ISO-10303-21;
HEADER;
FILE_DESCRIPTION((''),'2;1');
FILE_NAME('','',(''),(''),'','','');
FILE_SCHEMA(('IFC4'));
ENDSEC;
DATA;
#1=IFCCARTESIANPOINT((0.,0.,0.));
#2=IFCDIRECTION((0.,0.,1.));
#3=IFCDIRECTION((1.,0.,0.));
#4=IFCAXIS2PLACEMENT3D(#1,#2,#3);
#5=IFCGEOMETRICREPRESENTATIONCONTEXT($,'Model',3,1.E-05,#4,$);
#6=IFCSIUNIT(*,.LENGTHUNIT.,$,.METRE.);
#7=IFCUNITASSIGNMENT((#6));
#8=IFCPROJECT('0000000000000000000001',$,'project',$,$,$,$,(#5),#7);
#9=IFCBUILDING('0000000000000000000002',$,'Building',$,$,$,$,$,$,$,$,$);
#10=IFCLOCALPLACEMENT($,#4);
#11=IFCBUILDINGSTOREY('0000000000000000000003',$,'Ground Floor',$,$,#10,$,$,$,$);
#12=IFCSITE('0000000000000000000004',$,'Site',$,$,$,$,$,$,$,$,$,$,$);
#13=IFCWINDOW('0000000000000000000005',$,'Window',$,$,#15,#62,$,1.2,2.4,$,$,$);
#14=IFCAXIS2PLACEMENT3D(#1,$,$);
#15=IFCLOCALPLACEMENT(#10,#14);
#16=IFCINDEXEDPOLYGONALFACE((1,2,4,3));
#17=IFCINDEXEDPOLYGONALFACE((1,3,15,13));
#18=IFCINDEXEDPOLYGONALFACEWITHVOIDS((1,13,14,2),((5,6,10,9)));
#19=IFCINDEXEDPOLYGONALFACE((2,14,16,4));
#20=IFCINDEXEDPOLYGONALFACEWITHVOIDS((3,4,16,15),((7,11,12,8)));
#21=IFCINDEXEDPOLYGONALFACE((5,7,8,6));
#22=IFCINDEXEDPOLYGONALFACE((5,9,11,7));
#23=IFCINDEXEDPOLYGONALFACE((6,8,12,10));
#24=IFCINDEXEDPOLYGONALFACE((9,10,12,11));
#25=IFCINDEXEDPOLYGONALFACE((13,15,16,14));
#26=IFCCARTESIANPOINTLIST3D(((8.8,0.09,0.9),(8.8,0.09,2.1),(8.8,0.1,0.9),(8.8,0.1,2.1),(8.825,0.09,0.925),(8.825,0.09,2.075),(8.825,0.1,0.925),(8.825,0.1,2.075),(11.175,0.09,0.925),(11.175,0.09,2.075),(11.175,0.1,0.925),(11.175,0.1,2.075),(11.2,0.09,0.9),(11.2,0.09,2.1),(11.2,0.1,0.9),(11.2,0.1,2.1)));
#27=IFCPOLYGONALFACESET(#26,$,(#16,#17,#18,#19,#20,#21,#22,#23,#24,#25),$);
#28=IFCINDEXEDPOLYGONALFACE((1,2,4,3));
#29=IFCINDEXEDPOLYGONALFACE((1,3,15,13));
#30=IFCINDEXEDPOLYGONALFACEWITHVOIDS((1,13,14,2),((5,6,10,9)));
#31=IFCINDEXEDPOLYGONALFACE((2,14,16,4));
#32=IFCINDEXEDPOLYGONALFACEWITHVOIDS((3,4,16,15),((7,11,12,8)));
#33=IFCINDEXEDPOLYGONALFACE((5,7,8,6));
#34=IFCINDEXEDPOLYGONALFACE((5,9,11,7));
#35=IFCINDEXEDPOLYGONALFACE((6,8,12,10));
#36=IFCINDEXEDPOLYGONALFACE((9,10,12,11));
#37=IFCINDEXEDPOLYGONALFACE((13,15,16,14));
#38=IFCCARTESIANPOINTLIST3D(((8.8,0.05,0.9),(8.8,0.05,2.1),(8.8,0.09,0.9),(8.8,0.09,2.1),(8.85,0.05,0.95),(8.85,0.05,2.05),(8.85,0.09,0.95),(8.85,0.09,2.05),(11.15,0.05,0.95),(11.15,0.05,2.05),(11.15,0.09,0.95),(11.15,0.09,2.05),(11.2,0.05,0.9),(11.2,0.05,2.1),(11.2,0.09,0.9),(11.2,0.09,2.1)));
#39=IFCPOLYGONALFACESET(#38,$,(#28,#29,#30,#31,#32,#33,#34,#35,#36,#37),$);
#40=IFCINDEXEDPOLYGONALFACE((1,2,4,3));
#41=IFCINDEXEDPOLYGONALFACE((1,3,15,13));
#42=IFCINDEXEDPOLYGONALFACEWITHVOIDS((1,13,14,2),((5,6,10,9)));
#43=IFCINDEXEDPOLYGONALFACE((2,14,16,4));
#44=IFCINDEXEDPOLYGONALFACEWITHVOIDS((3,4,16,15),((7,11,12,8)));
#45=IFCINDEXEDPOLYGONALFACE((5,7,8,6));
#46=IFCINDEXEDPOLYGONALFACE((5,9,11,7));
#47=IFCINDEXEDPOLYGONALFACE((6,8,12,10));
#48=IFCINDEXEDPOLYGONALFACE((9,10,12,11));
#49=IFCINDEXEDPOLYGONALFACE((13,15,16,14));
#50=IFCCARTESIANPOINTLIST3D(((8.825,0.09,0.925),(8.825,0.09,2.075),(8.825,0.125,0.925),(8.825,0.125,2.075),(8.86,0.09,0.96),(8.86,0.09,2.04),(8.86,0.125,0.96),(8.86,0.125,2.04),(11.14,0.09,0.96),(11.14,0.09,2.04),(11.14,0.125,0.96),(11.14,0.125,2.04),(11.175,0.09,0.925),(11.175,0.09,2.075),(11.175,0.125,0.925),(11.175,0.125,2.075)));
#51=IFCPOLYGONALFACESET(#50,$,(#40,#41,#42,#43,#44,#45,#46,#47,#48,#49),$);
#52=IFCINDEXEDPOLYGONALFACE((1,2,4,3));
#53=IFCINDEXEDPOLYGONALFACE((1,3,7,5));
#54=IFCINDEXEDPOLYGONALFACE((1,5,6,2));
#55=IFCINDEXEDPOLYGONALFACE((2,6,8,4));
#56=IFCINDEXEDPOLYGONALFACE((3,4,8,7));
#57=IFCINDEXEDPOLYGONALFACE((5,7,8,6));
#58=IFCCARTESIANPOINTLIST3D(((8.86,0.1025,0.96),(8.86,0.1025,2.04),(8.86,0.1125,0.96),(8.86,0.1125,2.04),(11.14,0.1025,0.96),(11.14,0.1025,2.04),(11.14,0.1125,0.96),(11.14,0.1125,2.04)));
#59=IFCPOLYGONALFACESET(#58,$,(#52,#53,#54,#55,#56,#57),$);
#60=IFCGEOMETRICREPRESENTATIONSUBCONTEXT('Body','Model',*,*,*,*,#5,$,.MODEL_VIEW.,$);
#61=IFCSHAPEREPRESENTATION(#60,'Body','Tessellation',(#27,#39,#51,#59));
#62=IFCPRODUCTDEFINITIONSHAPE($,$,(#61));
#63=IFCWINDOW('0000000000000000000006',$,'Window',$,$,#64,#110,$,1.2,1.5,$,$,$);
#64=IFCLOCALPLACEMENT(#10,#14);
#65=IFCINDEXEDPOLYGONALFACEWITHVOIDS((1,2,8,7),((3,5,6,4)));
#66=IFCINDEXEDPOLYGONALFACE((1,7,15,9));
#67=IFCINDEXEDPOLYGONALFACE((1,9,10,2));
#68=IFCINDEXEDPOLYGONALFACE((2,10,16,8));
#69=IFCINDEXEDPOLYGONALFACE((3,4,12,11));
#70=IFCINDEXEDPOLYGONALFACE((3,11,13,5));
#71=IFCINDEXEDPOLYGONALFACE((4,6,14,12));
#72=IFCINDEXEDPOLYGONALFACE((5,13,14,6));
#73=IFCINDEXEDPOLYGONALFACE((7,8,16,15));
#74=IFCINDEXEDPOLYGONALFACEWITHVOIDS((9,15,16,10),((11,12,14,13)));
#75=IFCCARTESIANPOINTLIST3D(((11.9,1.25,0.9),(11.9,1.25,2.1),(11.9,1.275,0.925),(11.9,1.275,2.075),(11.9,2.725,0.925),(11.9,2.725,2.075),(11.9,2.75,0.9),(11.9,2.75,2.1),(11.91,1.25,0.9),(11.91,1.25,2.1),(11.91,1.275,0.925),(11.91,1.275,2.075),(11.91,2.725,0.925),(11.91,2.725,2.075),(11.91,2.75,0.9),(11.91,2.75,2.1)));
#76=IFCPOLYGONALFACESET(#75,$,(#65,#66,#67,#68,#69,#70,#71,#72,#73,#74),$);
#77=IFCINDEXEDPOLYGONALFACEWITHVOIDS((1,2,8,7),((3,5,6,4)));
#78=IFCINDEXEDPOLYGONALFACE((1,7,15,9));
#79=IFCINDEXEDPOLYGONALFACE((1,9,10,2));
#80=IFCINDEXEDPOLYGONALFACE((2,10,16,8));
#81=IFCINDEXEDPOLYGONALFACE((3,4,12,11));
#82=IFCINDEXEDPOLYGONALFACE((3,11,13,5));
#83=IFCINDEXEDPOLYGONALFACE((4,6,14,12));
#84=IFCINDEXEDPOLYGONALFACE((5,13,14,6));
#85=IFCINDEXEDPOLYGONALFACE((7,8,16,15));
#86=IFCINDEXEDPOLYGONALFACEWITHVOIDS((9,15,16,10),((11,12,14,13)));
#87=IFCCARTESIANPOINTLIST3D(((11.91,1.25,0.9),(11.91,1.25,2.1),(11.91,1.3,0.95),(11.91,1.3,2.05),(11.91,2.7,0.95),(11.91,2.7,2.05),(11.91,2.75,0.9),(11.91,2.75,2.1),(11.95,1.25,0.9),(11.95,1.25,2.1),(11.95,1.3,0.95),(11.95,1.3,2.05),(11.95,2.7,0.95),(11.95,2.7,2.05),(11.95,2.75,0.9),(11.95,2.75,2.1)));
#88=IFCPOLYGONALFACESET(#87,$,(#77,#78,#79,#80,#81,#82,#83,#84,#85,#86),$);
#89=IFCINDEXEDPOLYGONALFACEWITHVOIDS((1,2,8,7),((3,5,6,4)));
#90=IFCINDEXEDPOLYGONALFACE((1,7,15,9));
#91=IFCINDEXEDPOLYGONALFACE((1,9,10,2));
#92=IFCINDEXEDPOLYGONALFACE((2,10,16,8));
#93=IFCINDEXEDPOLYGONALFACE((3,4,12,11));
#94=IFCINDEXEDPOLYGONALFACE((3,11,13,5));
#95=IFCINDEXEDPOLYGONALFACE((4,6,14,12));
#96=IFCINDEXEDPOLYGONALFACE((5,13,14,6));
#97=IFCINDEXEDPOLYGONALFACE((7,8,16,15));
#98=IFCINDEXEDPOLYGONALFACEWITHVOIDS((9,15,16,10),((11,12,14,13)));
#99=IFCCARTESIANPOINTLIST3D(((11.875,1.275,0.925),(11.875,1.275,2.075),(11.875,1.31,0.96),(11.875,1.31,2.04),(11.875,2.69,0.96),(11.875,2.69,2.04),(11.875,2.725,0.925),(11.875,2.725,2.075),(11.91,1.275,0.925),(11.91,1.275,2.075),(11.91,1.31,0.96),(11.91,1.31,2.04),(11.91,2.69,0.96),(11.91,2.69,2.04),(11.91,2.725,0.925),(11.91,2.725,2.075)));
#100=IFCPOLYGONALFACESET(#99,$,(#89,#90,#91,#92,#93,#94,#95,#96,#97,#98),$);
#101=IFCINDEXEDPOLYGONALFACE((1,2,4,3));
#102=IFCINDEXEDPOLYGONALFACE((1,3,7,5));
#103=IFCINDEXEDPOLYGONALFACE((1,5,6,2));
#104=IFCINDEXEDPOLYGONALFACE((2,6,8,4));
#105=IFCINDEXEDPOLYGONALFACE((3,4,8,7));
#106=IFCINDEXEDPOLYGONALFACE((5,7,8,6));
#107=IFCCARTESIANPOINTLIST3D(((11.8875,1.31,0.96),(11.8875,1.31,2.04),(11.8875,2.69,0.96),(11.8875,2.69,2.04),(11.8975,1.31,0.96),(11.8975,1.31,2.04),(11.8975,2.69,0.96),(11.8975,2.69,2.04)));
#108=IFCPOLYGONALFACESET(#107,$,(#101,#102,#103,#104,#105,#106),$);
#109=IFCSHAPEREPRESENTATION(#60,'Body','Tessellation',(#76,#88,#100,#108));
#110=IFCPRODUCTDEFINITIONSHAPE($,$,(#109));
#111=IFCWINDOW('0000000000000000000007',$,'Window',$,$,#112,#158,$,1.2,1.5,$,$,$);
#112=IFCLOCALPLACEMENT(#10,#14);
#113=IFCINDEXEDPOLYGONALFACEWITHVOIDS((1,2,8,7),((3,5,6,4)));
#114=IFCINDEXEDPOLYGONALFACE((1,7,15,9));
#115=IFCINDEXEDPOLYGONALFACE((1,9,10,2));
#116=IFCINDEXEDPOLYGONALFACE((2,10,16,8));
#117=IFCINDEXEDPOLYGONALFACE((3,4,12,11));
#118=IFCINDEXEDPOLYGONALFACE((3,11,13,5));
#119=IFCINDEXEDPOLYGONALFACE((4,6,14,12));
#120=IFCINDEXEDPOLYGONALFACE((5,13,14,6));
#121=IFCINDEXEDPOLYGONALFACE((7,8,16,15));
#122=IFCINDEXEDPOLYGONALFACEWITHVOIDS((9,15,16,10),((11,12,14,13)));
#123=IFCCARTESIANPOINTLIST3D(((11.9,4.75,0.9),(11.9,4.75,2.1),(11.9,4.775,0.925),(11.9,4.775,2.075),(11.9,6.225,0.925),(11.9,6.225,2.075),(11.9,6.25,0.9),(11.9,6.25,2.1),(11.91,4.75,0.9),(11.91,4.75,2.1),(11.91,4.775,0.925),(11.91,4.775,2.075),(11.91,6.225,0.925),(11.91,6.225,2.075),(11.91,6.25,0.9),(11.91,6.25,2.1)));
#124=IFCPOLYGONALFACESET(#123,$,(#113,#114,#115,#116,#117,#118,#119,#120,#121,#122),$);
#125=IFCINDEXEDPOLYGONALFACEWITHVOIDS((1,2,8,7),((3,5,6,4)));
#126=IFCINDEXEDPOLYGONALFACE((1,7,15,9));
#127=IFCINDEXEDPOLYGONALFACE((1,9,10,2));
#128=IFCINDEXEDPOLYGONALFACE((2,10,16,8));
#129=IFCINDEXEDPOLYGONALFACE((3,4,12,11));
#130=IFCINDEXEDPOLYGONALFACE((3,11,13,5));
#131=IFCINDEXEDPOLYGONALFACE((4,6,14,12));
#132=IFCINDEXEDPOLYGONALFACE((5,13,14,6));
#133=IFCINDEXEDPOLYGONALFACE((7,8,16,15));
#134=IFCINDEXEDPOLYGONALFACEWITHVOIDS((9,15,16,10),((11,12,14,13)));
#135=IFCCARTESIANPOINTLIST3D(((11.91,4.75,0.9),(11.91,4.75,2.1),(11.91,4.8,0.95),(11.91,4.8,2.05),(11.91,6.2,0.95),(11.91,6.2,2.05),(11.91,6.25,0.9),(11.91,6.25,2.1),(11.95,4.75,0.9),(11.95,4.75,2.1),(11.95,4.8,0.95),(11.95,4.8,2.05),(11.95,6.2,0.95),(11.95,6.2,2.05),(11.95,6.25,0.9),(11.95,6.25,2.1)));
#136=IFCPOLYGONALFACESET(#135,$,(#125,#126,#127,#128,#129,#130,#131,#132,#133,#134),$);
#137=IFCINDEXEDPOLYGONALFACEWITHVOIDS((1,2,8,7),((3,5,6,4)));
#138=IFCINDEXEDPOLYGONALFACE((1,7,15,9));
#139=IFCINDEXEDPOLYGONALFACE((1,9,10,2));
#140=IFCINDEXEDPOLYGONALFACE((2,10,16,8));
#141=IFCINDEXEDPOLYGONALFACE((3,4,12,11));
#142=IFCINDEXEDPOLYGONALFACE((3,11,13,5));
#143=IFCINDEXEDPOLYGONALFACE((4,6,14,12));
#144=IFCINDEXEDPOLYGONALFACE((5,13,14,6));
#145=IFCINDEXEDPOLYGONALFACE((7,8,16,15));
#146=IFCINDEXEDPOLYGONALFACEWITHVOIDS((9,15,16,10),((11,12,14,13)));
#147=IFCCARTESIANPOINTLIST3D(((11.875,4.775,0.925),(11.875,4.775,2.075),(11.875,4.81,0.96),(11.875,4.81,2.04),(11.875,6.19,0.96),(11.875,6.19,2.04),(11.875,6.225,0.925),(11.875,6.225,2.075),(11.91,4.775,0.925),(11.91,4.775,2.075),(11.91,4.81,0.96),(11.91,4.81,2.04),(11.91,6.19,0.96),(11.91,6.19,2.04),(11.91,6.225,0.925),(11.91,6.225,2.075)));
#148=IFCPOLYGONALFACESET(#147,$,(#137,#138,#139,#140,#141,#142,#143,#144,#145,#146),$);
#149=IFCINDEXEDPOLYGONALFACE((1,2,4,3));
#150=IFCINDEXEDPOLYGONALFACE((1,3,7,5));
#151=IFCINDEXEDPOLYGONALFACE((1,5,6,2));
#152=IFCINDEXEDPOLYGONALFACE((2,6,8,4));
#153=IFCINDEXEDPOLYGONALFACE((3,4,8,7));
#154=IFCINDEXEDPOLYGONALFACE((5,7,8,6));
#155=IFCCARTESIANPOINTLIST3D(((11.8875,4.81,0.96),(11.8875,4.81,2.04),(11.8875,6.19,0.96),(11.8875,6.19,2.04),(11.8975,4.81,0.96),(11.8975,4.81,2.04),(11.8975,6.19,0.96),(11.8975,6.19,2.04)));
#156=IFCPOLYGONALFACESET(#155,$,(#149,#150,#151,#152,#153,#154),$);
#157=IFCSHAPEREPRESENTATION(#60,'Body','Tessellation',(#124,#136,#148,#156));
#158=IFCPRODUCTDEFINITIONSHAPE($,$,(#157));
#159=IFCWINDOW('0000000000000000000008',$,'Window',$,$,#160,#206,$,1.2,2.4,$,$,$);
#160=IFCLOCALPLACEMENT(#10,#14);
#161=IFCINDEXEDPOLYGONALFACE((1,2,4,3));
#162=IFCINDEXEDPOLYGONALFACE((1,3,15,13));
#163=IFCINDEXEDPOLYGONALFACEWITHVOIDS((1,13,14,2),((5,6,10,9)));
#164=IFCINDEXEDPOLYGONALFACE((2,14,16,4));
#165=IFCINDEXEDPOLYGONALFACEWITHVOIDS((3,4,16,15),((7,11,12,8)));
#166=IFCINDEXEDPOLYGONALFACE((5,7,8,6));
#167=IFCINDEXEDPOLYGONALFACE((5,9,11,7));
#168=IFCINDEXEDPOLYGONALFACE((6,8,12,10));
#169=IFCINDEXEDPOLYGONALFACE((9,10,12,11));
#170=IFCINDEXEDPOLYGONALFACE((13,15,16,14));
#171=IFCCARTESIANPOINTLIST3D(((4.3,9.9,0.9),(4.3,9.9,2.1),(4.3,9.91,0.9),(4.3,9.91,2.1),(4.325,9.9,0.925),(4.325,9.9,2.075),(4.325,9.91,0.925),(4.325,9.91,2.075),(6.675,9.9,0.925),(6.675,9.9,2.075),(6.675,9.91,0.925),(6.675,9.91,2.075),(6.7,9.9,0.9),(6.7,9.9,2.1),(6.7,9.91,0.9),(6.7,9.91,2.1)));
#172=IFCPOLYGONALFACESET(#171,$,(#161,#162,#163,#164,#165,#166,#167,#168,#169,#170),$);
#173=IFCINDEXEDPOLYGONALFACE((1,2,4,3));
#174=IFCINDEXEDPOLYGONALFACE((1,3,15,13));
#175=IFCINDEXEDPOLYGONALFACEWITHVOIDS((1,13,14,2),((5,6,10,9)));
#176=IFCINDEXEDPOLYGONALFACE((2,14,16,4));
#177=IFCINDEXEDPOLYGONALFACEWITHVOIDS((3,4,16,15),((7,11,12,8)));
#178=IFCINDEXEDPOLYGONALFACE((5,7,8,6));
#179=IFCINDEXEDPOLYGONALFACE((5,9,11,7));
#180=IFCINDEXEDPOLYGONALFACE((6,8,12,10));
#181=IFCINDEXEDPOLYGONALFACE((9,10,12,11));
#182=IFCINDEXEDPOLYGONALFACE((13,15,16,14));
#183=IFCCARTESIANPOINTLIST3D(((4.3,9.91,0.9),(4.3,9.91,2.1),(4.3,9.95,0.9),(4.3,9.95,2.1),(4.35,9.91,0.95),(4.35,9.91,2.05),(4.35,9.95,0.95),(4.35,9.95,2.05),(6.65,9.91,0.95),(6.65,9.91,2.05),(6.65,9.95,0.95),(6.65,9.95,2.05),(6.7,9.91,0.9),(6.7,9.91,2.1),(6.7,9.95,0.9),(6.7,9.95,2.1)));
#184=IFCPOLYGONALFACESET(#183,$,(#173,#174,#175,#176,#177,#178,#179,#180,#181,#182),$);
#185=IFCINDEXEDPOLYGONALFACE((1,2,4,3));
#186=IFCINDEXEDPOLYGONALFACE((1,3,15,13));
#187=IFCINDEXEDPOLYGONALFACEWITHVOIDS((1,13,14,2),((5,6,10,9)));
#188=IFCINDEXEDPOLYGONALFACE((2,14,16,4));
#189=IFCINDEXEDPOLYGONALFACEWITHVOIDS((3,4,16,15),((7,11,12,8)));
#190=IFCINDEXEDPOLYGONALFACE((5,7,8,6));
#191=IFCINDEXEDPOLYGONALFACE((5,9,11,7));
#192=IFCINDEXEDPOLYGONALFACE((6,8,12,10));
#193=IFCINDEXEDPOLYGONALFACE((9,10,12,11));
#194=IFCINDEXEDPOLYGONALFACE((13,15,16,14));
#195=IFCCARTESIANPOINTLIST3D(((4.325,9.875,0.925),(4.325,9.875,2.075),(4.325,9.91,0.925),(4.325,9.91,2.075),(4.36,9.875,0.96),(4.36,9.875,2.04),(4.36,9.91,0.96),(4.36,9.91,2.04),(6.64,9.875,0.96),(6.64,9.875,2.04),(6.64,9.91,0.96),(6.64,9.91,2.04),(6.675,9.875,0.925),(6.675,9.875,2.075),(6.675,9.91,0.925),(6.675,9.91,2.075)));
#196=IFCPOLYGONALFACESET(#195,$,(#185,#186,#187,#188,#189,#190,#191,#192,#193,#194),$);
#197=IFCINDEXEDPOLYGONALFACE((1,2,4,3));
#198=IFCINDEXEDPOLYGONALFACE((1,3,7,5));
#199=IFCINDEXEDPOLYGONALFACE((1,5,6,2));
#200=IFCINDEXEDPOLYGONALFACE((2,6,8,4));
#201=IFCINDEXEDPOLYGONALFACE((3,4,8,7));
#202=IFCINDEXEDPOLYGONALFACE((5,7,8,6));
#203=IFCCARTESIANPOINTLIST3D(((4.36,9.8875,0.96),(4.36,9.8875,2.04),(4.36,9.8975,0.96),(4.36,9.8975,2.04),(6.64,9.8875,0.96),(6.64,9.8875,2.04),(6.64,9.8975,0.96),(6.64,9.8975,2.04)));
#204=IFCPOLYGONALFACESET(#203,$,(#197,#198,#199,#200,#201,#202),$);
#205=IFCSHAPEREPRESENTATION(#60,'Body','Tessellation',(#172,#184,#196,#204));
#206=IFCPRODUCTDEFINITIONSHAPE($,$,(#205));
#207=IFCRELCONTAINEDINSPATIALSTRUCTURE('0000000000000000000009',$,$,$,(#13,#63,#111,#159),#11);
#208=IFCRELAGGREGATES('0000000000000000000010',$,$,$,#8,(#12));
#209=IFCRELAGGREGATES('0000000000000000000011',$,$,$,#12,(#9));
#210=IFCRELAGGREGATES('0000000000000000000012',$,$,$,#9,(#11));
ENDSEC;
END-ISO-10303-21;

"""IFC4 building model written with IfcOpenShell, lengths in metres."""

from ifc_helpers import new_model, si_unit, frame, origin_with_axes, place, context, subcontext, project, spatial, line, indexed_curve, outline, extrude, element, save


model = new_model("IFC4")

# Units and contexts
model_context = context("Model", 3, precision=1e-05, world=origin_with_axes())
body_context = subcontext(model_context, "Body", "Model", "MODEL_VIEW")
ifc_project = project(units=[si_unit("LENGTHUNIT", "METRE")], contexts=[model_context])

# Site, building, storey
site = spatial("IfcSite", under=ifc_project, Name="Site")
building = spatial("IfcBuilding", under=site, Name="Building")
storey_placement = place(None, origin_with_axes())
storey = spatial("IfcBuildingStorey", under=building, at=storey_placement, Name="Ground Floor")

# Windows
window_1_placement = place(storey_placement, frame((8.8, 0.0, 0.9), z_axis=(0.0, 0.0, 1.0), x_axis=(1.0, 0.0, 0.0)))
element("IfcWindow", 1, at=window_1_placement, inside=storey, Name="Window", OverallHeight=1.2, OverallWidth=2.4, context=body_context, shape_type="SweptSolid", body=[
    extrude(outline(indexed_curve([(0.0, 0.0), (2.4, 0.0), (2.4, 1.2), (0.0, 1.2)], segments=[line(1, 2, 3, 4, 1)]), holes=[indexed_curve([(0.025, 0.025), (2.375, 0.025), (2.375, 1.175), (0.025, 1.175)], segments=[line(1, 2, 3, 4, 1)])]), frame((0.0, 0.09, 0.0), z_axis=(0.0, -1.0, 0.0), x_axis=(1.0, 0.0, 0.0)), (0.0, 0.0, -1.0), 0.01),
    extrude(outline(indexed_curve([(0.0, 0.0), (2.4, 0.0), (2.4, 1.2), (0.0, 1.2)], segments=[line(1, 2, 3, 4, 1)]), holes=[indexed_curve([(0.05, 0.05), (2.35, 0.05), (2.35, 1.15), (0.05, 1.15)], segments=[line(1, 2, 3, 4, 1)])]), frame((0.0, 0.05, 0.0), z_axis=(0.0, -1.0, 0.0), x_axis=(1.0, 0.0, 0.0)), (0.0, 0.0, -1.0), 0.04),
    extrude(outline(indexed_curve([(0.0, 0.0), (2.35, 0.0), (2.35, 1.15), (0.0, 1.15)], segments=[line(1, 2, 3, 4, 1)]), holes=[indexed_curve([(0.035, 0.035), (2.315, 0.035), (2.315, 1.115), (0.035, 1.115)], segments=[line(1, 2, 3, 4, 1)])]), frame((0.025, 0.09, 0.025), z_axis=(0.0, -1.0, 0.0), x_axis=(1.0, 0.0, 0.0)), (0.0, 0.0, -1.0), 0.035),
    extrude(outline(indexed_curve([(0.035, 0.035), (2.315, 0.035), (2.315, 1.115), (0.035, 1.115)], segments=[line(1, 2, 3, 4, 1)])), frame((0.025, 0.1025, 0.025), z_axis=(0.0, -1.0, 0.0), x_axis=(1.0, 0.0, 0.0)), (0.0, 0.0, -1.0), 0.01),
])
for number, where, z_axis, x_axis, name in (
    (2, (12.0, 1.25, 0.9), (0.0, 0.0, 1.0), (0.0, 1.0, 0.0), "Window"),
    (3, (12.0, 4.75, 0.9), (0.0, 0.0, 1.0), (0.0, 1.0, 0.0), "Window"),
):
    element("IfcWindow", number, at=place(storey_placement, frame(where, z_axis=z_axis, x_axis=x_axis)), inside=storey, Name=name, OverallHeight=1.2, OverallWidth=1.5, context=body_context, shape_type="SweptSolid", body=[
        extrude(outline(indexed_curve([(0.0, 0.0), (1.5, 0.0), (1.5, 1.2), (0.0, 1.2)], segments=[line(1, 2, 3, 4, 1)]), holes=[indexed_curve([(0.025, 0.025), (1.475, 0.025), (1.475, 1.175), (0.025, 1.175)], segments=[line(1, 2, 3, 4, 1)])]), frame((0.0, 0.09, 0.0), z_axis=(0.0, -1.0, 0.0), x_axis=(1.0, 0.0, 0.0)), (0.0, 0.0, -1.0), 0.01),
        extrude(outline(indexed_curve([(0.0, 0.0), (1.5, 0.0), (1.5, 1.2), (0.0, 1.2)], segments=[line(1, 2, 3, 4, 1)]), holes=[indexed_curve([(0.05, 0.05), (1.45, 0.05), (1.45, 1.15), (0.05, 1.15)], segments=[line(1, 2, 3, 4, 1)])]), frame((0.0, 0.05, 0.0), z_axis=(0.0, -1.0, 0.0), x_axis=(1.0, 0.0, 0.0)), (0.0, 0.0, -1.0), 0.04),
        extrude(outline(indexed_curve([(0.0, 0.0), (1.45, 0.0), (1.45, 1.15), (0.0, 1.15)], segments=[line(1, 2, 3, 4, 1)]), holes=[indexed_curve([(0.035, 0.035), (1.415, 0.035), (1.415, 1.115), (0.035, 1.115)], segments=[line(1, 2, 3, 4, 1)])]), frame((0.025, 0.09, 0.025), z_axis=(0.0, -1.0, 0.0), x_axis=(1.0, 0.0, 0.0)), (0.0, 0.0, -1.0), 0.035),
        extrude(outline(indexed_curve([(0.035, 0.035), (1.415, 0.035), (1.415, 1.115), (0.035, 1.115)], segments=[line(1, 2, 3, 4, 1)])), frame((0.025, 0.1025, 0.025), z_axis=(0.0, -1.0, 0.0), x_axis=(1.0, 0.0, 0.0)), (0.0, 0.0, -1.0), 0.01),
    ])
window_2_placement = place(storey_placement, frame((6.7, 10.0, 0.9), z_axis=(0.0, 0.0, 1.0), x_axis=(-1.0, 0.0, 0.0)))
element("IfcWindow", 4, at=window_2_placement, inside=storey, Name="Window", OverallHeight=1.2, OverallWidth=2.4, context=body_context, shape_type="SweptSolid", body=[
    extrude(outline(indexed_curve([(0.0, 0.0), (2.4, 0.0), (2.4, 1.2), (0.0, 1.2)], segments=[line(1, 2, 3, 4, 1)]), holes=[indexed_curve([(0.025, 0.025), (2.375, 0.025), (2.375, 1.175), (0.025, 1.175)], segments=[line(1, 2, 3, 4, 1)])]), frame((0.0, 0.09, 0.0), z_axis=(0.0, -1.0, 0.0), x_axis=(1.0, 0.0, 0.0)), (0.0, 0.0, -1.0), 0.01),
    extrude(outline(indexed_curve([(0.0, 0.0), (2.4, 0.0), (2.4, 1.2), (0.0, 1.2)], segments=[line(1, 2, 3, 4, 1)]), holes=[indexed_curve([(0.05, 0.05), (2.35, 0.05), (2.35, 1.15), (0.05, 1.15)], segments=[line(1, 2, 3, 4, 1)])]), frame((0.0, 0.05, 0.0), z_axis=(0.0, -1.0, 0.0), x_axis=(1.0, 0.0, 0.0)), (0.0, 0.0, -1.0), 0.04),
    extrude(outline(indexed_curve([(0.0, 0.0), (2.35, 0.0), (2.35, 1.15), (0.0, 1.15)], segments=[line(1, 2, 3, 4, 1)]), holes=[indexed_curve([(0.035, 0.035), (2.315, 0.035), (2.315, 1.115), (0.035, 1.115)], segments=[line(1, 2, 3, 4, 1)])]), frame((0.025, 0.09, 0.025), z_axis=(0.0, -1.0, 0.0), x_axis=(1.0, 0.0, 0.0)), (0.0, 0.0, -1.0), 0.035),
    extrude(outline(indexed_curve([(0.035, 0.035), (2.315, 0.035), (2.315, 1.115), (0.035, 1.115)], segments=[line(1, 2, 3, 4, 1)])), frame((0.025, 0.1025, 0.025), z_axis=(0.0, -1.0, 0.0), x_axis=(1.0, 0.0, 0.0)), (0.0, 0.0, -1.0), 0.01),
])

save(model, "model.ifc")
